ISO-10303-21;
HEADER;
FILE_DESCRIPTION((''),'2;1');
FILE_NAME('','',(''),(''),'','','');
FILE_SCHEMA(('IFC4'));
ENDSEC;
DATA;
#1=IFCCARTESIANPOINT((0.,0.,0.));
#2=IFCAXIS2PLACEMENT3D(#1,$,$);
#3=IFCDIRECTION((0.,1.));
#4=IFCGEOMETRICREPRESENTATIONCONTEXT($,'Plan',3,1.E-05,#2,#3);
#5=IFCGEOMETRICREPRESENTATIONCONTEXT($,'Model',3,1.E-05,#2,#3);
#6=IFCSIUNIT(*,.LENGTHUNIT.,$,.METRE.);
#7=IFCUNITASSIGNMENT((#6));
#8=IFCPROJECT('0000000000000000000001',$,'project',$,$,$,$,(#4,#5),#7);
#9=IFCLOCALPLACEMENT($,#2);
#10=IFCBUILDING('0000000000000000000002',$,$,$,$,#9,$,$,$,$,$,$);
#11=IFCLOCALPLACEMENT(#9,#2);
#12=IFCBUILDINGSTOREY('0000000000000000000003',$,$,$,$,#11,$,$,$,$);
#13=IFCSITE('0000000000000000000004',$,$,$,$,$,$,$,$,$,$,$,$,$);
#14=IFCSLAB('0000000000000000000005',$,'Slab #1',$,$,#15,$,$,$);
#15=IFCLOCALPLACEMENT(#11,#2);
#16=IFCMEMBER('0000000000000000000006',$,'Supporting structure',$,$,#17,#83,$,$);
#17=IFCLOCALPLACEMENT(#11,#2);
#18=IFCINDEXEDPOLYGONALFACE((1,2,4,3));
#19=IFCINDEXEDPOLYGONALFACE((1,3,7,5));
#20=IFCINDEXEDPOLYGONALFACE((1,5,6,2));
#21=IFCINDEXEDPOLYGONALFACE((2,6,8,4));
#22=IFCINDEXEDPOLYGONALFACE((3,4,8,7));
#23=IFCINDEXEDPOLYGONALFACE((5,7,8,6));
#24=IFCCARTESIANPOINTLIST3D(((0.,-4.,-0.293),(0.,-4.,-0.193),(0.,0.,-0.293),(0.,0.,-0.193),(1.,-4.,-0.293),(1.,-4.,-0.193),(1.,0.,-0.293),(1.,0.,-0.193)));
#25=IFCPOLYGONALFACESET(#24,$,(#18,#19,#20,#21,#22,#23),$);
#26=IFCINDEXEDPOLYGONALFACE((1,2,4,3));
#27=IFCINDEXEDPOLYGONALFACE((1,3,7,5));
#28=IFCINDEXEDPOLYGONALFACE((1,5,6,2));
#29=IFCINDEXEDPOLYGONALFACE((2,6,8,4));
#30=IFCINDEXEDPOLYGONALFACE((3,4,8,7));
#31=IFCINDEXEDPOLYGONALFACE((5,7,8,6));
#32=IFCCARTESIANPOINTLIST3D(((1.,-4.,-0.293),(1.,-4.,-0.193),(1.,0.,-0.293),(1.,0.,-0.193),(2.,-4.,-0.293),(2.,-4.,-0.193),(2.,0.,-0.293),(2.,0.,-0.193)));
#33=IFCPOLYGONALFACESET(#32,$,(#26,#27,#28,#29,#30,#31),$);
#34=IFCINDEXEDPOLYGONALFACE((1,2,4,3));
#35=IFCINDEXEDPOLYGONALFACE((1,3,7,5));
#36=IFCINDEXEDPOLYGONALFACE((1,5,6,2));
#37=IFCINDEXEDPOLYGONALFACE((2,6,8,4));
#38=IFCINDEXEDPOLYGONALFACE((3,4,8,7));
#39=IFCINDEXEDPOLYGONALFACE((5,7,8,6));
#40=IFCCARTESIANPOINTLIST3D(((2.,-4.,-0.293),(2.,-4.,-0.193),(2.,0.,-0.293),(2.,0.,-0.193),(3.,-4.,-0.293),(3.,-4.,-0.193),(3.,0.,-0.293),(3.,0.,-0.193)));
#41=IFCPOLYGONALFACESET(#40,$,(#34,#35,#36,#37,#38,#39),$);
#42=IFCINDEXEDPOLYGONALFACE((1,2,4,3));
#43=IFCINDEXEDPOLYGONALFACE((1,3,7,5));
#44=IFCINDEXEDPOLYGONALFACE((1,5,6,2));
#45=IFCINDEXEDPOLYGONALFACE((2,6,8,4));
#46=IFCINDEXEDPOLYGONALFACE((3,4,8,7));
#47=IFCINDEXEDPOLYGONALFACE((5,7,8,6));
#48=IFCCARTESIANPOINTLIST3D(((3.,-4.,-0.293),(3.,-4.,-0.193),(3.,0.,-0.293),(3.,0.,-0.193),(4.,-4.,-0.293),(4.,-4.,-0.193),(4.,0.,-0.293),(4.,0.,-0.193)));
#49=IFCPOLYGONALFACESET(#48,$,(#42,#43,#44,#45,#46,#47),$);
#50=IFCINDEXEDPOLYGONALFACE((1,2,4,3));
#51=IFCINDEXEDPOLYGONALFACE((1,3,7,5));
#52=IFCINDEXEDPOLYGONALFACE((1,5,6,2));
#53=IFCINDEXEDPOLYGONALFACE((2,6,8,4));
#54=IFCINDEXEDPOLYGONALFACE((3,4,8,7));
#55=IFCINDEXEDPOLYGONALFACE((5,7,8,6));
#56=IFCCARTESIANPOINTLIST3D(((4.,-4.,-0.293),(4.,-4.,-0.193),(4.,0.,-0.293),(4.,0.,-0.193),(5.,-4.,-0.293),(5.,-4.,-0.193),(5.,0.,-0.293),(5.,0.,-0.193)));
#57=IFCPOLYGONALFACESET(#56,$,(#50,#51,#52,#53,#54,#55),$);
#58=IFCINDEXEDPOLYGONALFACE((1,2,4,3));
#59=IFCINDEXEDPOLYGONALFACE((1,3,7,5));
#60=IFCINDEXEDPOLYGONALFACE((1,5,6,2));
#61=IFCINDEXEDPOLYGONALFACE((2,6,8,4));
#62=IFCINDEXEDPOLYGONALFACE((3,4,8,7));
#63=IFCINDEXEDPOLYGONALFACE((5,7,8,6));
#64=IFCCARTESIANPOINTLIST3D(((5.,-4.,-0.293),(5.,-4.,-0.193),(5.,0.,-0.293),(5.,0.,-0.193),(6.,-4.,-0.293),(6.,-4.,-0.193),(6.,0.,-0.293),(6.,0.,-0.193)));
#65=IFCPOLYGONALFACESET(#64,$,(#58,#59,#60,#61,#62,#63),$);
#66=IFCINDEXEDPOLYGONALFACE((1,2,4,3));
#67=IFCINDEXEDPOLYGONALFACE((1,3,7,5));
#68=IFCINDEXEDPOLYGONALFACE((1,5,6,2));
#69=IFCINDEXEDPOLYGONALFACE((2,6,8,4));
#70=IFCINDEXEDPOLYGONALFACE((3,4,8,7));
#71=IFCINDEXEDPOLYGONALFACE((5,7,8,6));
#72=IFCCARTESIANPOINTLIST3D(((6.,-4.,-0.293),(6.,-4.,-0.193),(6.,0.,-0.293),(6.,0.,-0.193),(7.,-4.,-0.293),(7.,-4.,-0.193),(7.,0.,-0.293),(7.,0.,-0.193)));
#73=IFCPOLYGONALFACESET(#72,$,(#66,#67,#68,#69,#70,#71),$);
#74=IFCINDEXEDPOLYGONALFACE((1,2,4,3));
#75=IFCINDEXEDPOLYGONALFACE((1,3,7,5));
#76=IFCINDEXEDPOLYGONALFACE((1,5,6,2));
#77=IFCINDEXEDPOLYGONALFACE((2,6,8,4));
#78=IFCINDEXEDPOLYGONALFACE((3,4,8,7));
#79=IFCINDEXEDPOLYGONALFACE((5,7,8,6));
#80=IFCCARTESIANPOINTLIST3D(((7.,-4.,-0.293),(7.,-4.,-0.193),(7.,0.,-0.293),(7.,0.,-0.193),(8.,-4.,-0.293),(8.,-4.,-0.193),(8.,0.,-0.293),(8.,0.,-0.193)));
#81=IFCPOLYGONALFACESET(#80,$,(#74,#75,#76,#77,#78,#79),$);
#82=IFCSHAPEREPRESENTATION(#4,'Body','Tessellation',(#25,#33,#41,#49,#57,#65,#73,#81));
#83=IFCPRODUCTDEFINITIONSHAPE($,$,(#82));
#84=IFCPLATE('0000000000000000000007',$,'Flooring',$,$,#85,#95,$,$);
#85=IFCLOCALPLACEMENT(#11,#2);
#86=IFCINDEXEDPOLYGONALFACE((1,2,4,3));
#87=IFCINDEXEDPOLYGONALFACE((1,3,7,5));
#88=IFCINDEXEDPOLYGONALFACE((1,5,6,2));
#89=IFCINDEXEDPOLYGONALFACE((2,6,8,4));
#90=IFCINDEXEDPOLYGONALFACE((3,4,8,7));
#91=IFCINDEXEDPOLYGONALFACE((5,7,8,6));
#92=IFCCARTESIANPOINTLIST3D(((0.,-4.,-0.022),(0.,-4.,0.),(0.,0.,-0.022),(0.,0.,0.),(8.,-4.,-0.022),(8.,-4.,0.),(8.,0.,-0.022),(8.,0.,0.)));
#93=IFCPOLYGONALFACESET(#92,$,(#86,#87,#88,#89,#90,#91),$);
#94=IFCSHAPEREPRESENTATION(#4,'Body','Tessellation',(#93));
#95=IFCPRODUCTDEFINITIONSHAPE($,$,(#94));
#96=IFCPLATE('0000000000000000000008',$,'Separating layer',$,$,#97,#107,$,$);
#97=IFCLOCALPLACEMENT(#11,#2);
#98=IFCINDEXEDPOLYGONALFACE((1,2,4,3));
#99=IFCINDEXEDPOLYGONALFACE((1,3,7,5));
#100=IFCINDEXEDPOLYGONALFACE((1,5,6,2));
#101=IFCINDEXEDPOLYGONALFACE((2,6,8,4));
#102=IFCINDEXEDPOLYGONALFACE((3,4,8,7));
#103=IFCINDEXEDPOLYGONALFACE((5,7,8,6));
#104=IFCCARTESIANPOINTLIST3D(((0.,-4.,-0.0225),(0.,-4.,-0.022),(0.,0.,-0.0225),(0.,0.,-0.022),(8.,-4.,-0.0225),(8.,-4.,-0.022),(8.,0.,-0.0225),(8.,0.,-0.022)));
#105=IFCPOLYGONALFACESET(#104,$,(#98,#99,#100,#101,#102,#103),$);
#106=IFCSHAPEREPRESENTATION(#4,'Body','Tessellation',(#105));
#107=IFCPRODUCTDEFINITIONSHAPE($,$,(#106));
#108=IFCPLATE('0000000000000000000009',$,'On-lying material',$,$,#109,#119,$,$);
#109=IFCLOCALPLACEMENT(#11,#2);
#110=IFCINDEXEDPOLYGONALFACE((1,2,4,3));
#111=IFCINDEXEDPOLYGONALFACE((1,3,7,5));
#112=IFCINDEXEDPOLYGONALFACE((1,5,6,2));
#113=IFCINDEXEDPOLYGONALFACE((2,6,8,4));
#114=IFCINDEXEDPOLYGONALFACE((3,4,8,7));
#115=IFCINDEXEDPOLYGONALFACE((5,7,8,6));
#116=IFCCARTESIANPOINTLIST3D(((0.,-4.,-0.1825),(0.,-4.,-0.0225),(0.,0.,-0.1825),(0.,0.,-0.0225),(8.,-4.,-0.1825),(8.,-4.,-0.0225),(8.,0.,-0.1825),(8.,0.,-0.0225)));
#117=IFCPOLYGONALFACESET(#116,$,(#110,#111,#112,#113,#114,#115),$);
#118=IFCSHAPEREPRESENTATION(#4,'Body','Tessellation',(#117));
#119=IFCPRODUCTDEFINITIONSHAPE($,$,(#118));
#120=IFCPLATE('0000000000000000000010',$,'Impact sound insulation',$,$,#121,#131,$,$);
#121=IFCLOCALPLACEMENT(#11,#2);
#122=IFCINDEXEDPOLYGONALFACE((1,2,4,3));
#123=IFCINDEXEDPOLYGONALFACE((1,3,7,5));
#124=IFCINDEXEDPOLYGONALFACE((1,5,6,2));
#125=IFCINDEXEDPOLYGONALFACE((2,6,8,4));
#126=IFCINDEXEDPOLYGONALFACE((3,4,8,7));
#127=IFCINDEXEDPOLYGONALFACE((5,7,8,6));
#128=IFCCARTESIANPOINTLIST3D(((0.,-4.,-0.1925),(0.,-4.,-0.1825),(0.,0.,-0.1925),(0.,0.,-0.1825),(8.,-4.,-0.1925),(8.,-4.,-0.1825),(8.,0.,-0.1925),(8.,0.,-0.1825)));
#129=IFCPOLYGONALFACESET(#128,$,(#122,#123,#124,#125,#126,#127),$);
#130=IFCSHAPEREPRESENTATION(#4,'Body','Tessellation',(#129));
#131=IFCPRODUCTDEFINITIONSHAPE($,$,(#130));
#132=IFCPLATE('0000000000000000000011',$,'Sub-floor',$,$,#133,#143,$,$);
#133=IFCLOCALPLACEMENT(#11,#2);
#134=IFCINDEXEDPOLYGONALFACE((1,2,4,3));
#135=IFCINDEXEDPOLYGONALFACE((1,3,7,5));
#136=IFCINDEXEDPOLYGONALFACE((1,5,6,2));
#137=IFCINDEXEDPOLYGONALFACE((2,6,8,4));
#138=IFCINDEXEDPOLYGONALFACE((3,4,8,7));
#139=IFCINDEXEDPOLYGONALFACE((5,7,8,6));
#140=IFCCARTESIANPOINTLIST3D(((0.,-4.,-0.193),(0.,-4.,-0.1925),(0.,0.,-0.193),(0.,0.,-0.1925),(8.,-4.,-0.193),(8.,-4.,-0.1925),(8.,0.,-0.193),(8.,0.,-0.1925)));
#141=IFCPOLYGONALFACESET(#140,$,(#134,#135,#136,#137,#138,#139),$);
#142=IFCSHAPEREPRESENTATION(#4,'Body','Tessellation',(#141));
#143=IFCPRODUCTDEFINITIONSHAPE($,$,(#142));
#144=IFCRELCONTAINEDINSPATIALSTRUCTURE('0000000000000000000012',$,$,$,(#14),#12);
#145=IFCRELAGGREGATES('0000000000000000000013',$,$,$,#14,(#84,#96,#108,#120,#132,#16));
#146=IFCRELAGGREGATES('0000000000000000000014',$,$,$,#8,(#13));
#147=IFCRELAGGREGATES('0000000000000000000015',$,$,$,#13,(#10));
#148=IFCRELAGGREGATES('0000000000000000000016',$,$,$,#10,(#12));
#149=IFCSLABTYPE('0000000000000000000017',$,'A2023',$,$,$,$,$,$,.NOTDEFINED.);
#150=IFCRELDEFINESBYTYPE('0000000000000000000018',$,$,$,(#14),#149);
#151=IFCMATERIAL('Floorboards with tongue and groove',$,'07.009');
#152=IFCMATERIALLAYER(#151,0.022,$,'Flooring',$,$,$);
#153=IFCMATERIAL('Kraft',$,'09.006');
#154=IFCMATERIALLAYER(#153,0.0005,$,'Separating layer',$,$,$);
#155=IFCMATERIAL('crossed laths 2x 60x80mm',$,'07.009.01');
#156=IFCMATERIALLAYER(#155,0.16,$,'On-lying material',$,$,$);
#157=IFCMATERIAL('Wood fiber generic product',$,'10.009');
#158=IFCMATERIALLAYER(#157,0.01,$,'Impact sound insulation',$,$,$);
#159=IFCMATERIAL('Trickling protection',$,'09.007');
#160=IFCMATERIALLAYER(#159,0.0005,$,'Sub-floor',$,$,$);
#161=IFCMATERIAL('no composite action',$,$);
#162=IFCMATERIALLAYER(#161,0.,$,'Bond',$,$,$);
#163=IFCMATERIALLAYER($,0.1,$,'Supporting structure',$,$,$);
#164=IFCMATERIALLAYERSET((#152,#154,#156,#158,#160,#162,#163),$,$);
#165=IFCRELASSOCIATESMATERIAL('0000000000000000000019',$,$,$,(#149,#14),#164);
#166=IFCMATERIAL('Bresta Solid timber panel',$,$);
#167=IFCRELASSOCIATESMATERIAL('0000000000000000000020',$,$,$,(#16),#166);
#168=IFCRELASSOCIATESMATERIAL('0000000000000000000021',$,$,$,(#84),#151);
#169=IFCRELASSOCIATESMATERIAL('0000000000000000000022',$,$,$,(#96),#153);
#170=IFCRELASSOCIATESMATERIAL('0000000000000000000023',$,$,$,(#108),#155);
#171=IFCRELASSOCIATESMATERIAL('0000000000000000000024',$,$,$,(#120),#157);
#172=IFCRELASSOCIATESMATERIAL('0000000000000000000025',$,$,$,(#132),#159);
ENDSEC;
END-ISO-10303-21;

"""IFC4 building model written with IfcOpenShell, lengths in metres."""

from ifc_helpers import new_model, si_unit, direction, frame, frame_2d, origin, origin_with_axes, place, context, project, spatial, rectangle, extrude, material, layer, layer_set, type_object, element, aggregate, save


model = new_model("IFC4")

# Units and contexts
plan_context = context("Plan", 3, precision=1e-05, world=origin(), true_north=direction((0.0, 1.0)))
model_context = context("Model", 3, precision=1e-05, world=origin(), true_north=direction((0.0, 1.0)))
ifc_project = project(units=[si_unit("LENGTHUNIT", "METRE")], contexts=[plan_context, model_context])

# Site, building, storey
site = spatial("IfcSite", under=ifc_project)
building_placement = place(None, origin())
building = spatial("IfcBuilding", under=site, at=building_placement)
storey_placement = place(building_placement, origin())
storey = spatial("IfcBuildingStorey", under=building, at=storey_placement)

# Slab, member, plates
ifc_material_1 = material(Name="Floorboards with tongue and groove", Category="07.009")
ifc_layer_1 = layer(ifc_material_1, 0.022, Name="Flooring")
ifc_material_2 = material(Name="Kraft", Category="09.006")
ifc_layer_2 = layer(ifc_material_2, 0.0005, Name="Separating layer")
ifc_material_3 = material(Name="crossed laths 2x 60x80mm", Category="07.009.01")
ifc_layer_3 = layer(ifc_material_3, 0.16, Name="On-lying material")
ifc_material_4 = material(Name="Wood fiber generic product", Category="10.009")
ifc_layer_4 = layer(ifc_material_4, 0.01, Name="Impact sound insulation")
ifc_material_5 = material(Name="Trickling protection", Category="09.007")
ifc_layer_5 = layer(ifc_material_5, 0.0005, Name="Sub-floor")
ifc_material_6 = material(Name="no composite action")
ifc_layer_6 = layer(ifc_material_6, 0.0, Name="Bond")
ifc_layer_7 = layer(None, 0.1, Name="Supporting structure")
ifc_layer_set = layer_set([ifc_layer_1, ifc_layer_2, ifc_layer_3, ifc_layer_4, ifc_layer_5, ifc_layer_6, ifc_layer_7])
slab_type = type_object("IfcSlabType", Name="A2023", PredefinedType="NOTDEFINED", material=ifc_layer_set)
slab_placement = place(None, frame((0.0, 0.0, 0.0), z_axis=(0.0, 0.0, -1.0), x_axis=(1.0, 0.0, 0.0)))
slab = element("IfcSlab", 1, at=slab_placement, inside=storey, type_object=slab_type, material=ifc_layer_set, Name="Slab #1")
ifc_material_7 = material(Name="Bresta Solid timber panel")
member_placement = place(slab_placement, origin())
member = element("IfcMember", 2, at=member_placement, material=ifc_material_7, Name="Supporting structure", context=plan_context, shape_type="SweptSolid", body=[
    extrude(rectangle(XDim=1.0, YDim=0.1, at=frame_2d((0.5, 0.05), x_axis=(1.0, 0.0))), frame((0.0, 4.0, 0.193), z_axis=(0.0, -1.0, 0.0), x_axis=(1.0, 0.0, 0.0)), (0.0, 0.0, 1.0), 4.0),
    extrude(rectangle(XDim=1.0, YDim=0.1, at=frame_2d((0.5, 0.05), x_axis=(1.0, 0.0))), frame((1.0, 4.0, 0.193), z_axis=(0.0, -1.0, 0.0), x_axis=(1.0, 0.0, 0.0)), (0.0, 0.0, 1.0), 4.0),
    extrude(rectangle(XDim=1.0, YDim=0.1, at=frame_2d((0.5, 0.05), x_axis=(1.0, 0.0))), frame((2.0, 4.0, 0.193), z_axis=(0.0, -1.0, 0.0), x_axis=(1.0, 0.0, 0.0)), (0.0, 0.0, 1.0), 4.0),
    extrude(rectangle(XDim=1.0, YDim=0.1, at=frame_2d((0.5, 0.05), x_axis=(1.0, 0.0))), frame((3.0, 4.0, 0.193), z_axis=(0.0, -1.0, 0.0), x_axis=(1.0, 0.0, 0.0)), (0.0, 0.0, 1.0), 4.0),
    extrude(rectangle(XDim=1.0, YDim=0.1, at=frame_2d((0.5, 0.05), x_axis=(1.0, 0.0))), frame((4.0, 4.0, 0.193), z_axis=(0.0, -1.0, 0.0), x_axis=(1.0, 0.0, 0.0)), (0.0, 0.0, 1.0), 4.0),
    extrude(rectangle(XDim=1.0, YDim=0.1, at=frame_2d((0.5, 0.05), x_axis=(1.0, 0.0))), frame((5.0, 4.0, 0.193), z_axis=(0.0, -1.0, 0.0), x_axis=(1.0, 0.0, 0.0)), (0.0, 0.0, 1.0), 4.0),
    extrude(rectangle(XDim=1.0, YDim=0.1, at=frame_2d((0.5, 0.05), x_axis=(1.0, 0.0))), frame((6.0, 4.0, 0.193), z_axis=(0.0, -1.0, 0.0), x_axis=(1.0, 0.0, 0.0)), (0.0, 0.0, 1.0), 4.0),
    extrude(rectangle(XDim=1.0, YDim=0.1, at=frame_2d((0.5, 0.05), x_axis=(1.0, 0.0))), frame((7.0, 4.0, 0.193), z_axis=(0.0, -1.0, 0.0), x_axis=(1.0, 0.0, 0.0)), (0.0, 0.0, 1.0), 4.0),
])
plate_1_placement = place(slab_placement, origin())
plate_1 = element("IfcPlate", 3, at=plate_1_placement, material=ifc_material_1, Name="Flooring", context=plan_context, shape_type="SweptSolid", body=[
    extrude(rectangle(XDim=8.0, YDim=4.0, at=frame_2d((4.0, 2.0), x_axis=(1.0, 0.0))), origin_with_axes(), (0.0, 0.0, 1.0), 0.022),
])
plate_2_placement = place(slab_placement, origin())
plate_2 = element("IfcPlate", 4, at=plate_2_placement, material=ifc_material_2, Name="Separating layer", context=plan_context, shape_type="SweptSolid", body=[
    extrude(rectangle(XDim=8.0, YDim=4.0, at=frame_2d((4.0, 2.0), x_axis=(1.0, 0.0))), frame((0.0, 0.0, 0.022), z_axis=(0.0, 0.0, 1.0), x_axis=(1.0, 0.0, 0.0)), (0.0, 0.0, 1.0), 0.0005),
])
plate_3_placement = place(slab_placement, origin())
plate_3 = element("IfcPlate", 5, at=plate_3_placement, material=ifc_material_3, Name="On-lying material", context=plan_context, shape_type="SweptSolid", body=[
    extrude(rectangle(XDim=8.0, YDim=4.0, at=frame_2d((4.0, 2.0), x_axis=(1.0, 0.0))), frame((0.0, 0.0, 0.0225), z_axis=(0.0, 0.0, 1.0), x_axis=(1.0, 0.0, 0.0)), (0.0, 0.0, 1.0), 0.16),
])
plate_4_placement = place(slab_placement, origin())
plate_4 = element("IfcPlate", 6, at=plate_4_placement, material=ifc_material_4, Name="Impact sound insulation", context=plan_context, shape_type="SweptSolid", body=[
    extrude(rectangle(XDim=8.0, YDim=4.0, at=frame_2d((4.0, 2.0), x_axis=(1.0, 0.0))), frame((0.0, 0.0, 0.1825), z_axis=(0.0, 0.0, 1.0), x_axis=(1.0, 0.0, 0.0)), (0.0, 0.0, 1.0), 0.01),
])
plate_5_placement = place(slab_placement, origin())
plate_5 = element("IfcPlate", 7, at=plate_5_placement, material=ifc_material_5, Name="Sub-floor", context=plan_context, shape_type="SweptSolid", body=[
    extrude(rectangle(XDim=8.0, YDim=4.0, at=frame_2d((4.0, 2.0), x_axis=(1.0, 0.0))), frame((0.0, 0.0, 0.1925), z_axis=(0.0, 0.0, 1.0), x_axis=(1.0, 0.0, 0.0)), (0.0, 0.0, 1.0), 0.0005),
])
aggregate(slab, [plate_1, plate_2, plate_3, plate_4, plate_5, member])

save(model, "model.ifc")
